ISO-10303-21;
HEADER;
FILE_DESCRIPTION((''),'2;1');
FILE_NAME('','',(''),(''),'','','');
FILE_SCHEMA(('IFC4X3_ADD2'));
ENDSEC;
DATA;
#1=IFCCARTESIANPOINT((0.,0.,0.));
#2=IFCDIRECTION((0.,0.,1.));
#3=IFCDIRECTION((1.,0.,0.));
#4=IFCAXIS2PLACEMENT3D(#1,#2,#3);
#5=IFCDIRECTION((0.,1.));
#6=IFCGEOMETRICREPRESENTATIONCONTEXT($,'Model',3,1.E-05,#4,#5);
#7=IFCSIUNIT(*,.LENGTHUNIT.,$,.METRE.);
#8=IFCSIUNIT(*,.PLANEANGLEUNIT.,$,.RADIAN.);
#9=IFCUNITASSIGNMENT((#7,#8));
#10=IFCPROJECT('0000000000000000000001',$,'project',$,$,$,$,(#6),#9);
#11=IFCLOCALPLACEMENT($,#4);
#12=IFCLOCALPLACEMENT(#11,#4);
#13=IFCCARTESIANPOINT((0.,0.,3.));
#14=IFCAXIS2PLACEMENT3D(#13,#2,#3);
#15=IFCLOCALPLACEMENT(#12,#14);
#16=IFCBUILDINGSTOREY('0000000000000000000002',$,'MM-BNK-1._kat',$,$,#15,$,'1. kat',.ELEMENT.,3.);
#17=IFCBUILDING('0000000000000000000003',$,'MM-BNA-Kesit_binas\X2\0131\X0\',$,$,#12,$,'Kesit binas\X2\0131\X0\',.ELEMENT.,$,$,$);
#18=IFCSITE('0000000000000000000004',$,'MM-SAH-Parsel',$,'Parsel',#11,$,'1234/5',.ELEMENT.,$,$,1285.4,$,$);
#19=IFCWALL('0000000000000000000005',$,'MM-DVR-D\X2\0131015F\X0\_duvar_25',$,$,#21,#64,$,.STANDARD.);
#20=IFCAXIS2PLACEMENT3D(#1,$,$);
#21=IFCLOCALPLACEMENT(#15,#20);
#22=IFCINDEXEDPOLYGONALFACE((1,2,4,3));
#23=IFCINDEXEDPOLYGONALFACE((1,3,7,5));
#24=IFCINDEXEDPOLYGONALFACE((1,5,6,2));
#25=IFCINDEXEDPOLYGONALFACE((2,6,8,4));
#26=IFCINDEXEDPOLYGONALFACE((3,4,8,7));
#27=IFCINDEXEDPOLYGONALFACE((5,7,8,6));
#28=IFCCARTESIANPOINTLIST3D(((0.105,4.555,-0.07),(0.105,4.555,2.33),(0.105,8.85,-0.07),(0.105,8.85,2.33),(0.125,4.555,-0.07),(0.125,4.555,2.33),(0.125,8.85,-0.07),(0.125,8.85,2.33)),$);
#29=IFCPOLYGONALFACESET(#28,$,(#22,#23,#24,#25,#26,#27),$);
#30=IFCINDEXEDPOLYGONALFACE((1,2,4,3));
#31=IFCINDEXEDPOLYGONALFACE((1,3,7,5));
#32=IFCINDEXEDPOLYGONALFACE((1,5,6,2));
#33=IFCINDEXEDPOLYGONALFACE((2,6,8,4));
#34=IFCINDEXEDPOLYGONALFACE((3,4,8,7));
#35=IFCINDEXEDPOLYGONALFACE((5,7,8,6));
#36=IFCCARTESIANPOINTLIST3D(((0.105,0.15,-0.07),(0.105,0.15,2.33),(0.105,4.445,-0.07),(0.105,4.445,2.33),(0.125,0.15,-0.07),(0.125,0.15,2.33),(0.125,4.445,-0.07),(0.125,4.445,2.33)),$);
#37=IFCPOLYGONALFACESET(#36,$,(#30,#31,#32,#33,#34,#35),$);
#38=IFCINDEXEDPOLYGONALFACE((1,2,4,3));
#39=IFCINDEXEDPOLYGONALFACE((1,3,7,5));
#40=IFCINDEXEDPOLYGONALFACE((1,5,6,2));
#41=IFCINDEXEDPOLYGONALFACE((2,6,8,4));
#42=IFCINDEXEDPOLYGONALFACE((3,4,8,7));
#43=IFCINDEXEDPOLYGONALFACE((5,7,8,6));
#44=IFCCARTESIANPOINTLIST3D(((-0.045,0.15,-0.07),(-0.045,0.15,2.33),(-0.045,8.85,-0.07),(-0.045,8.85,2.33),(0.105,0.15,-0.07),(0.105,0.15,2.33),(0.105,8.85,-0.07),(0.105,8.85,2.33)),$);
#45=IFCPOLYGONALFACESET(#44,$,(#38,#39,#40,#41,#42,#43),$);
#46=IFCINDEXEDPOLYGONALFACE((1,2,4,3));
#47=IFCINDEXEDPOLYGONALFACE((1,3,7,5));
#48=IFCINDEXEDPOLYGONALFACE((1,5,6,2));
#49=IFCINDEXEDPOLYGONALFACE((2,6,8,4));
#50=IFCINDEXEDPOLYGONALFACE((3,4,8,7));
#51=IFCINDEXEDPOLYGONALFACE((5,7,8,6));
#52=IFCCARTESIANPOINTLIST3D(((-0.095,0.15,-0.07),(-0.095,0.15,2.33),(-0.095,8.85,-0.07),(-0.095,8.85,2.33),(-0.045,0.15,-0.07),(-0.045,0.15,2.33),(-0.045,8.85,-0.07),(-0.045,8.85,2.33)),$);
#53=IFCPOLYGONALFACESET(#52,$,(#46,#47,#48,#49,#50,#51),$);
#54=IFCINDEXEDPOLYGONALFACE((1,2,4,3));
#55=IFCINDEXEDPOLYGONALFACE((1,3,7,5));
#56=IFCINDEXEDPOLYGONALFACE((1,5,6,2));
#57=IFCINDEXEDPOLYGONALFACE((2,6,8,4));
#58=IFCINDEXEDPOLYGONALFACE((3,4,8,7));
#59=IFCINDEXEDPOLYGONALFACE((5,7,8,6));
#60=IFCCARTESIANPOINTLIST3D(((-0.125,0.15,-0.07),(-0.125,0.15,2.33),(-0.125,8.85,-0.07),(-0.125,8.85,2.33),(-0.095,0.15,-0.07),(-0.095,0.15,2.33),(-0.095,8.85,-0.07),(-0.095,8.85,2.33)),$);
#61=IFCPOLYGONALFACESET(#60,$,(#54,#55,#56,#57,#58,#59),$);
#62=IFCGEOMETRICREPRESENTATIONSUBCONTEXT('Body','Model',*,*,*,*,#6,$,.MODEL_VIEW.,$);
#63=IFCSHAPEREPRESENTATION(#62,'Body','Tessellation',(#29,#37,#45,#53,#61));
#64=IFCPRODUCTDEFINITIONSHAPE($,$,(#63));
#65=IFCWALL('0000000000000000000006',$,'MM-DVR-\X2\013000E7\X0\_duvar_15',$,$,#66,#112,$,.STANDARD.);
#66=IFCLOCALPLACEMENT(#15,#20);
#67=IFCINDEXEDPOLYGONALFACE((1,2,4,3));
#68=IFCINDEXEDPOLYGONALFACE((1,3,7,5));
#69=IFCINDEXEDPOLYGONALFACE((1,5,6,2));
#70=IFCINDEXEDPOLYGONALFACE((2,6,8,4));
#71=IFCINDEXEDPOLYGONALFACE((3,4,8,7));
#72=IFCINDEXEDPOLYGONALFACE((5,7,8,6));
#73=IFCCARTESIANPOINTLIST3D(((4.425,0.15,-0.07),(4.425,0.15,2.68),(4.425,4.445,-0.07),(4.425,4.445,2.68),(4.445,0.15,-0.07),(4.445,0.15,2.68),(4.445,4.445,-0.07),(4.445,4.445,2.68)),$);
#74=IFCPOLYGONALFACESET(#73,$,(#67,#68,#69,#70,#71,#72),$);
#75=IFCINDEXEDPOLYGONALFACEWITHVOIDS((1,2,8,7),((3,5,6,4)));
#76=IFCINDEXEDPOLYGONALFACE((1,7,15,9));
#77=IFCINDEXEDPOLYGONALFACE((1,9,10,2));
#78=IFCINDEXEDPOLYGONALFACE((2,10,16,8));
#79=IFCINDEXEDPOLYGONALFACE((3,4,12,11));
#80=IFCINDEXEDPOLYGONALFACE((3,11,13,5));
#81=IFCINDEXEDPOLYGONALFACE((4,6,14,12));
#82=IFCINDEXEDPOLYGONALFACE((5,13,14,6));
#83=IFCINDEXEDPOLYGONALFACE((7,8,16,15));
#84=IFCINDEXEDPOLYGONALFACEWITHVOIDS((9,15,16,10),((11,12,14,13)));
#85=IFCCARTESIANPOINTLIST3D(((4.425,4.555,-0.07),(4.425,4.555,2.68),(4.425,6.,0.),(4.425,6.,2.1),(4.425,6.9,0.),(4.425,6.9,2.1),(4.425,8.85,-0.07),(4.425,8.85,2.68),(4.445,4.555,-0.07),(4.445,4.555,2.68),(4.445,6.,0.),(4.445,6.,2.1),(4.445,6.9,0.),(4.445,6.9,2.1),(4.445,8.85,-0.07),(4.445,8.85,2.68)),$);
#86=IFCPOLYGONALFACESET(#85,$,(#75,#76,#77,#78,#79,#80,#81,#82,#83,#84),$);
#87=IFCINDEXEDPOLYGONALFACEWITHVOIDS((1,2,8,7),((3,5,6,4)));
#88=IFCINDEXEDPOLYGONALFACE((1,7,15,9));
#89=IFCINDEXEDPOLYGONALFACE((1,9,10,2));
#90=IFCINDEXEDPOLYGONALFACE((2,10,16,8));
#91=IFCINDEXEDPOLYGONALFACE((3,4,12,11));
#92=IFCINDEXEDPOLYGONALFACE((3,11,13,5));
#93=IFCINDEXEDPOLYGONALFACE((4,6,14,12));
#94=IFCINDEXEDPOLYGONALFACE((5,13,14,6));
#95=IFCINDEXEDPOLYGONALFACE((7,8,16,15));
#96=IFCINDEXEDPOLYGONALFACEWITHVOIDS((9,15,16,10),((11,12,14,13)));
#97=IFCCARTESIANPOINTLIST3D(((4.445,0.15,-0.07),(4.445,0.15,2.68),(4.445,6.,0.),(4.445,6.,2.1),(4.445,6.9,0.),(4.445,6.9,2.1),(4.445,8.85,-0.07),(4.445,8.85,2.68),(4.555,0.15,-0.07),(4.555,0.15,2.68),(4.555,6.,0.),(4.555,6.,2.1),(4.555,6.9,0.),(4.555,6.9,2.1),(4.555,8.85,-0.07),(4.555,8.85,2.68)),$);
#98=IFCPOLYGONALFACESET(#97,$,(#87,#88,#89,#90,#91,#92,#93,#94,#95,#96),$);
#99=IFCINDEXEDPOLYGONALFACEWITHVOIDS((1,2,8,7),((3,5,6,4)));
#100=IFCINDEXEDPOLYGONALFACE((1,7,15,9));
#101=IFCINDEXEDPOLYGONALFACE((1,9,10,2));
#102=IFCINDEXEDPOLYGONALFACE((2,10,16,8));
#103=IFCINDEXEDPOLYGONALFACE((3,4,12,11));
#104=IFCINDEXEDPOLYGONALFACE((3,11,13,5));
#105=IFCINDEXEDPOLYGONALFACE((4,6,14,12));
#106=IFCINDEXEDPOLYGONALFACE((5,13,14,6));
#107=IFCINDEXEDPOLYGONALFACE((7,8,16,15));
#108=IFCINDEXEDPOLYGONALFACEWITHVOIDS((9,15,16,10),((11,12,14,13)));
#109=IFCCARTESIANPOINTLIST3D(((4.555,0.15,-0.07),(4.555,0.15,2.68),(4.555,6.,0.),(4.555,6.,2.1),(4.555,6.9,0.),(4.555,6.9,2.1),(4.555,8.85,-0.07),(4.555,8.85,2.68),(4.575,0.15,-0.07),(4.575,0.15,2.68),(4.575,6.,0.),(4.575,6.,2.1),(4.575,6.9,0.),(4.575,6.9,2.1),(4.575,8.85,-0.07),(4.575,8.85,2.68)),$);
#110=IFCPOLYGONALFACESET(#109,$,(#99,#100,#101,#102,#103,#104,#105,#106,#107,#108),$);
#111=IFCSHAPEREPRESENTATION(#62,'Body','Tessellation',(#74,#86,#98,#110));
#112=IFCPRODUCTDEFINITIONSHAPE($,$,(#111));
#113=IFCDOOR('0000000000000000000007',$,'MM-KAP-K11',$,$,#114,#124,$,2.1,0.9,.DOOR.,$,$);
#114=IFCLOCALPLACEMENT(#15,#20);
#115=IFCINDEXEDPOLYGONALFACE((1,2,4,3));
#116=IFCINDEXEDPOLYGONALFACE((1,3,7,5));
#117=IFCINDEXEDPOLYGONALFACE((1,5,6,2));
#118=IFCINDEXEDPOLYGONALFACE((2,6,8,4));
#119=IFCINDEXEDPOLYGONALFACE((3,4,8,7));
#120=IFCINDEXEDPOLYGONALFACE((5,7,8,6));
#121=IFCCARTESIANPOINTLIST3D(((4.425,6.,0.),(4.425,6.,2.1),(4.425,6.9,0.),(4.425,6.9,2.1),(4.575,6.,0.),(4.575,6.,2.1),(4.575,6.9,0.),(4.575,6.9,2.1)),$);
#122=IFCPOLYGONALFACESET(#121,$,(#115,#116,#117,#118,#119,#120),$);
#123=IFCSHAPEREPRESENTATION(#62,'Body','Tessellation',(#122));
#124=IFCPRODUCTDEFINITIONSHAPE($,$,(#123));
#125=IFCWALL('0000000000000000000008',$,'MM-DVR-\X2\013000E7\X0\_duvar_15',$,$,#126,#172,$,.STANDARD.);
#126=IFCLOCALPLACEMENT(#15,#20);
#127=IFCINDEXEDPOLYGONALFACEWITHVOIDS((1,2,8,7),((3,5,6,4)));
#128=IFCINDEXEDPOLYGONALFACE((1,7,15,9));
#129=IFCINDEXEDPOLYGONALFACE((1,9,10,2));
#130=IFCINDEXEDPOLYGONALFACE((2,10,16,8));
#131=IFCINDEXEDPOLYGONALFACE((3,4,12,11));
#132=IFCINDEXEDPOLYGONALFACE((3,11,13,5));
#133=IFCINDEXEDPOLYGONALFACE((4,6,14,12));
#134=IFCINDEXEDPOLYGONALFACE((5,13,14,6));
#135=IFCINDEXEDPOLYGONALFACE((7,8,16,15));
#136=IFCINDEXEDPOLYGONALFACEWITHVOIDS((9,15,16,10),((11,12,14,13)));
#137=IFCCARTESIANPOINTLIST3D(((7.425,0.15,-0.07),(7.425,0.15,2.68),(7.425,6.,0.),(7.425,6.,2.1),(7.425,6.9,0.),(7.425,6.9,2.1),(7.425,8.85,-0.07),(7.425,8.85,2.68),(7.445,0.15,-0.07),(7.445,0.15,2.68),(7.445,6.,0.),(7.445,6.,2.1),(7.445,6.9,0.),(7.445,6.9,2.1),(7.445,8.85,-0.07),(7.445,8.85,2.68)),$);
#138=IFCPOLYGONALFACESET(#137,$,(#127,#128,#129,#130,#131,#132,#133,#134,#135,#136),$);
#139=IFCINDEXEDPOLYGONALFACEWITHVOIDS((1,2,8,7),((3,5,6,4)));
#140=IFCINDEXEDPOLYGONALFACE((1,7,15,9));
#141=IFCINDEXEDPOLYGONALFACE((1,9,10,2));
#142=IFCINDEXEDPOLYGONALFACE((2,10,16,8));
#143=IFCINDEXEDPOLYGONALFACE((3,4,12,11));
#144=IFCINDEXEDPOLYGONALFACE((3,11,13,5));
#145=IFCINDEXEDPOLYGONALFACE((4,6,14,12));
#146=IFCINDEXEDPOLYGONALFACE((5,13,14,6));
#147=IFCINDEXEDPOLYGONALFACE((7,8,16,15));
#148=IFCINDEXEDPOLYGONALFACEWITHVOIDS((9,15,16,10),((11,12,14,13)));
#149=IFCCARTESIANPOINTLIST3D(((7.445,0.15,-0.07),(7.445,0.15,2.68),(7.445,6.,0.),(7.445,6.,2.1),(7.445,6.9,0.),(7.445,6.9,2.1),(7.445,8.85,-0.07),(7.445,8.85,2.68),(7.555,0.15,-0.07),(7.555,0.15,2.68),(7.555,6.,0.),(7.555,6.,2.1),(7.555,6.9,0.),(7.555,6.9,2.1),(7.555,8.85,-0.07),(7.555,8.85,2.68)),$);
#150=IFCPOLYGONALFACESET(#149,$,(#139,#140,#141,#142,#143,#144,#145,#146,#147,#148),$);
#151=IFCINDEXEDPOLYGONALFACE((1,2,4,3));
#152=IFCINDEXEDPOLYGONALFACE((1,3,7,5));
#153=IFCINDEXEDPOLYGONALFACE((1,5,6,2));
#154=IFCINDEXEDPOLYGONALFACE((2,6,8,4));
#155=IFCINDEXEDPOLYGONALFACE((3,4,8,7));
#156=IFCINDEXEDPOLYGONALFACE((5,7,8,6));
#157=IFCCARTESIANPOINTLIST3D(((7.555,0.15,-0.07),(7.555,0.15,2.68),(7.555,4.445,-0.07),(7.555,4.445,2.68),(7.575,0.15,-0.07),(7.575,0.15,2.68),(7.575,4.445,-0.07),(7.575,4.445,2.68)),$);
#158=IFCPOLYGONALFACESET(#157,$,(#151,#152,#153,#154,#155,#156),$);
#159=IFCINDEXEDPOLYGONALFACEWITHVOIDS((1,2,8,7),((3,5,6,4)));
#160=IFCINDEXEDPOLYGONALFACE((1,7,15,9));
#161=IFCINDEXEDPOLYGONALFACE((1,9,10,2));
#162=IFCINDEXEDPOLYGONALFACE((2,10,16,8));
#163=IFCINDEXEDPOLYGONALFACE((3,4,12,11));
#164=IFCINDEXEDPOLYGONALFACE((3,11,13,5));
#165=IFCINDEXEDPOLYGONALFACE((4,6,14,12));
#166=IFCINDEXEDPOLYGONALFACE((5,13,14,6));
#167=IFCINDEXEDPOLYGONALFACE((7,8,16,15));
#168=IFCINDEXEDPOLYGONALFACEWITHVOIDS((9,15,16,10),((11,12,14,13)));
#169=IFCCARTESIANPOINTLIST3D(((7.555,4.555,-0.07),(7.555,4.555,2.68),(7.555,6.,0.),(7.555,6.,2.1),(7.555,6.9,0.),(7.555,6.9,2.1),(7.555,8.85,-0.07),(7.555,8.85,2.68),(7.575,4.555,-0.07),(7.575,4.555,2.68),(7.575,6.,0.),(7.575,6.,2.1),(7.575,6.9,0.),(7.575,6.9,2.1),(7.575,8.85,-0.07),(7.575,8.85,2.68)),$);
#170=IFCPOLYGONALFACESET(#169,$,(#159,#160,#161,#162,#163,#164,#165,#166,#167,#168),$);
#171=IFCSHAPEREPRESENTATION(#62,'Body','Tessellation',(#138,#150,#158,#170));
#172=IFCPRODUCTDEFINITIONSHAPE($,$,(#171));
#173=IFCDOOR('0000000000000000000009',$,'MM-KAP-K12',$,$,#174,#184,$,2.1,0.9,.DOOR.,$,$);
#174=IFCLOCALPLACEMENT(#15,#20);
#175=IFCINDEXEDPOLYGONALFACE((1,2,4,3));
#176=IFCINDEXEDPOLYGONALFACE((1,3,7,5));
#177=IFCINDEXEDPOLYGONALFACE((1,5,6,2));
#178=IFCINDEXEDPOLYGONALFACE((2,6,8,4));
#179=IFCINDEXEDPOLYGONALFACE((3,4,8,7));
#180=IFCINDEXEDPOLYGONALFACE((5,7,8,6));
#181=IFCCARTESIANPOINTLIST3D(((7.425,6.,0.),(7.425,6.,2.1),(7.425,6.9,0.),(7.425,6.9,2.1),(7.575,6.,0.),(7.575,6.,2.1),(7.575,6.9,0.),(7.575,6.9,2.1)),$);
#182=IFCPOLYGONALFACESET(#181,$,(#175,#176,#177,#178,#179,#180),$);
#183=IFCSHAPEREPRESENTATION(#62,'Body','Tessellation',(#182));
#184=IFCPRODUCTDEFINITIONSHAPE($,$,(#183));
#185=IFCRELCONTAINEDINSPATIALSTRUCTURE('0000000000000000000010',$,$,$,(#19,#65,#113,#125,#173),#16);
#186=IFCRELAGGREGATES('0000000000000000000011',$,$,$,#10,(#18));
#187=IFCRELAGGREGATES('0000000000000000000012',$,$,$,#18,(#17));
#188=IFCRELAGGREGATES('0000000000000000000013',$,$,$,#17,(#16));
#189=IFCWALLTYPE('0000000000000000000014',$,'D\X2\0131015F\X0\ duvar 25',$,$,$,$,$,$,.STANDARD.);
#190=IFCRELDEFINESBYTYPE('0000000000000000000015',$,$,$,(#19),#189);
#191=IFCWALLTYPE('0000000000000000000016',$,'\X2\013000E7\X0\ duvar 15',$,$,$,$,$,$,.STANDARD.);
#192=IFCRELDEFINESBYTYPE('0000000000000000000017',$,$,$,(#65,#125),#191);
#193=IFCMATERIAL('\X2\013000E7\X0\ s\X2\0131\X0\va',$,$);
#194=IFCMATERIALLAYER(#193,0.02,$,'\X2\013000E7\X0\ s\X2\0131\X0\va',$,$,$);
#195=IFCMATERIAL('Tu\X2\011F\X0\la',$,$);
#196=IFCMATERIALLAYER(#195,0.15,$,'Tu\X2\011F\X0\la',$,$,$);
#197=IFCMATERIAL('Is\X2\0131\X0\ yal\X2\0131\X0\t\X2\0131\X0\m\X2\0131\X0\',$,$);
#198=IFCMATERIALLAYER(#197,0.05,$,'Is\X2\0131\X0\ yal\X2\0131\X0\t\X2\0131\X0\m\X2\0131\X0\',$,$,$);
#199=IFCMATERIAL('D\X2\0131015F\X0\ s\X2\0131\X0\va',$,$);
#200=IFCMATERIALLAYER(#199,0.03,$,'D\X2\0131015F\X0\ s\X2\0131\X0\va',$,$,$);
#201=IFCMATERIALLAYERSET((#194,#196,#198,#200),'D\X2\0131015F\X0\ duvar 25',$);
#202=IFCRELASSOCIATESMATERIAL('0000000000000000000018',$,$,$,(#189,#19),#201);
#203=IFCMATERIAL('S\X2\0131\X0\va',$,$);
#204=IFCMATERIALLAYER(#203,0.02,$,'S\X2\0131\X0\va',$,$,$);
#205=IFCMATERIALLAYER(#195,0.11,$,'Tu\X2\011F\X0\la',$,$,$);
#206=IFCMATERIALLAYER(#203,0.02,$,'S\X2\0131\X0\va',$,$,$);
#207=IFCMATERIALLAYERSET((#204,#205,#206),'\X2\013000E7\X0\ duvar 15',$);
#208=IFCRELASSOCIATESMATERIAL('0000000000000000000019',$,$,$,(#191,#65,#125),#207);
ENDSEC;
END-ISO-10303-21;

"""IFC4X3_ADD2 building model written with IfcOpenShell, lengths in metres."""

from ifc_helpers import new_model, si_unit, direction, frame, origin, origin_with_axes, place, context, subcontext, project, spatial, polyline, outline, extrude, material, layer, layer_set, type_object, element, fill, save


model = new_model("IFC4X3_ADD2")

# Units and contexts
model_context = context("Model", 3, precision=1e-05, world=origin_with_axes(), true_north=direction((0.0, 1.0)))
body_context = subcontext(model_context, "Body", "Model", "MODEL_VIEW")
ifc_project = project(units=[si_unit("LENGTHUNIT", "METRE"), si_unit("PLANEANGLEUNIT", "RADIAN")], contexts=[model_context])

# Site, building, storey
site_placement = place(None, origin_with_axes())
site = spatial("IfcSite", under=ifc_project, at=site_placement, Name="MM-SAH-Parsel", ObjectType="Parsel", LongName="1234/5", CompositionType="ELEMENT", RefElevation=1285.4)
building_placement = place(site_placement, origin_with_axes())
building = spatial("IfcBuilding", under=site, at=building_placement, Name="MM-BNA-Kesit_binası", LongName="Kesit binası", CompositionType="ELEMENT")
storey_placement = place(building_placement, frame((0.0, 0.0, 3.0), z_axis=(0.0, 0.0, 1.0), x_axis=(1.0, 0.0, 0.0)))
storey = spatial("IfcBuildingStorey", under=building, at=storey_placement, Name="MM-BNK-1._kat", LongName="1. kat", CompositionType="ELEMENT", Elevation=3.0)

# Shared definitions
ifc_material_1 = material(Name="İç sıva")
ifc_layer_1 = layer(ifc_material_1, 0.02, Name="İç sıva")
ifc_material_2 = material(Name="Tuğla")
ifc_layer_2 = layer(ifc_material_2, 0.15, Name="Tuğla")
ifc_material_3 = material(Name="Isı yalıtımı")
ifc_layer_3 = layer(ifc_material_3, 0.05, Name="Isı yalıtımı")
ifc_material_4 = material(Name="Dış sıva")
ifc_layer_4 = layer(ifc_material_4, 0.03, Name="Dış sıva")
ifc_layer_set_1 = layer_set([ifc_layer_1, ifc_layer_2, ifc_layer_3, ifc_layer_4], Name="Dış duvar 25")
wall_type_1 = type_object("IfcWallType", Name="Dış duvar 25", PredefinedType="STANDARD", material=ifc_layer_set_1)

# Wall
wall_1_placement = place(storey_placement, origin_with_axes())
element("IfcWall", 1, at=wall_1_placement, inside=storey, type_object=wall_type_1, material=ifc_layer_set_1, Name="MM-DVR-Dış_duvar_25", PredefinedType="STANDARD", context=body_context, shape_type="SweptSolid", body=[
    extrude(outline(polyline([(0.105, 8.85), (0.105, 4.555), (0.125, 4.555), (0.125, 8.85), (0.105, 8.85)])), frame((0.0, 0.0, -0.07)), (0.0, 0.0, 1.0), 2.4),
    extrude(outline(polyline([(0.105, 4.445), (0.105, 0.15), (0.125, 0.15), (0.125, 4.445), (0.105, 4.445)])), frame((0.0, 0.0, -0.07)), (0.0, 0.0, 1.0), 2.4),
    extrude(outline(polyline([(-0.045, 8.85), (-0.045, 0.15), (0.105, 0.15), (0.105, 8.85), (-0.045, 8.85)])), frame((0.0, 0.0, -0.07)), (0.0, 0.0, 1.0), 2.4),
    extrude(outline(polyline([(-0.095, 8.85), (-0.095, 0.15), (-0.045, 0.15), (-0.045, 8.85), (-0.095, 8.85)])), frame((0.0, 0.0, -0.07)), (0.0, 0.0, 1.0), 2.4),
    extrude(outline(polyline([(-0.125, 8.85), (-0.125, 0.15), (-0.095, 0.15), (-0.095, 8.85), (-0.125, 8.85)])), frame((0.0, 0.0, -0.07)), (0.0, 0.0, 1.0), 2.4),
])

# Walls, openings, doors
ifc_material_5 = material(Name="Sıva")
ifc_layer_5 = layer(ifc_material_5, 0.02, Name="Sıva")
ifc_layer_6 = layer(ifc_material_2, 0.11, Name="Tuğla")
ifc_layer_7 = layer(ifc_material_5, 0.02, Name="Sıva")
ifc_layer_set_2 = layer_set([ifc_layer_5, ifc_layer_6, ifc_layer_7], Name="İç duvar 15")
wall_type_2 = type_object("IfcWallType", Name="İç duvar 15", PredefinedType="STANDARD", material=ifc_layer_set_2)
wall_2_placement = place(storey_placement, origin_with_axes())
wall_2 = element("IfcWall", 2, at=wall_2_placement, inside=storey, type_object=wall_type_2, material=ifc_layer_set_2, Name="MM-DVR-İç_duvar_15", PredefinedType="STANDARD", context=body_context, shape_type="SweptSolid", body=[
    extrude(outline(polyline([(4.445, 0.15), (4.445, 4.445), (4.425, 4.445), (4.425, 0.15), (4.445, 0.15)])), frame((0.0, 0.0, -0.07)), (0.0, 0.0, 1.0), 2.75),
    extrude(outline(polyline([(4.445, 4.555), (4.445, 8.85), (4.425, 8.85), (4.425, 4.555), (4.445, 4.555)])), frame((0.0, 0.0, -0.07)), (0.0, 0.0, 1.0), 2.75),
    extrude(outline(polyline([(4.555, 0.15), (4.555, 8.85), (4.445, 8.85), (4.445, 0.15), (4.555, 0.15)])), frame((0.0, 0.0, -0.07)), (0.0, 0.0, 1.0), 2.75),
    extrude(outline(polyline([(4.575, 0.15), (4.575, 8.85), (4.555, 8.85), (4.555, 0.15), (4.575, 0.15)])), frame((0.0, 0.0, -0.07)), (0.0, 0.0, 1.0), 2.75),
])
opening_1_placement = place(storey_placement, origin_with_axes())
opening_1 = element("IfcOpeningElement", 3, at=opening_1_placement, cuts=wall_2, PredefinedType="OPENING", context=body_context, shape_type="SweptSolid", body=[
    extrude(outline(polyline([(4.425, 6.0), (4.425, 6.9), (4.575, 6.9), (4.575, 6.0), (4.425, 6.0)])), origin(), (0.0, 0.0, 1.0), 2.1),
])
door_1_placement = place(storey_placement, origin_with_axes())
door_1 = element("IfcDoor", 4, at=door_1_placement, inside=storey, Name="MM-KAP-K11", OverallHeight=2.1, OverallWidth=0.9, PredefinedType="DOOR", context=body_context, shape_type="SweptSolid", body=[
    extrude(outline(polyline([(4.425, 6.0), (4.425, 6.9), (4.575, 6.9), (4.575, 6.0), (4.425, 6.0)])), origin(), (0.0, 0.0, 1.0), 2.1),
])
fill(opening_1, door_1)
wall_3_placement = place(storey_placement, origin_with_axes())
wall_3 = element("IfcWall", 5, at=wall_3_placement, inside=storey, type_object=wall_type_2, material=ifc_layer_set_2, Name="MM-DVR-İç_duvar_15", PredefinedType="STANDARD", context=body_context, shape_type="SweptSolid", body=[
    extrude(outline(polyline([(7.445, 0.15), (7.445, 8.85), (7.425, 8.85), (7.425, 0.15), (7.445, 0.15)])), frame((0.0, 0.0, -0.07)), (0.0, 0.0, 1.0), 2.75),
    extrude(outline(polyline([(7.555, 0.15), (7.555, 8.85), (7.445, 8.85), (7.445, 0.15), (7.555, 0.15)])), frame((0.0, 0.0, -0.07)), (0.0, 0.0, 1.0), 2.75),
    extrude(outline(polyline([(7.575, 0.15), (7.575, 4.445), (7.555, 4.445), (7.555, 0.15), (7.575, 0.15)])), frame((0.0, 0.0, -0.07)), (0.0, 0.0, 1.0), 2.75),
    extrude(outline(polyline([(7.575, 4.555), (7.575, 8.85), (7.555, 8.85), (7.555, 4.555), (7.575, 4.555)])), frame((0.0, 0.0, -0.07)), (0.0, 0.0, 1.0), 2.75),
])
opening_2_placement = place(storey_placement, origin_with_axes())
opening_2 = element("IfcOpeningElement", 6, at=opening_2_placement, cuts=wall_3, PredefinedType="OPENING", context=body_context, shape_type="SweptSolid", body=[
    extrude(outline(polyline([(7.425, 6.0), (7.425, 6.9), (7.575, 6.9), (7.575, 6.0), (7.425, 6.0)])), origin(), (0.0, 0.0, 1.0), 2.1),
])
door_2_placement = place(storey_placement, origin_with_axes())
door_2 = element("IfcDoor", 7, at=door_2_placement, inside=storey, Name="MM-KAP-K12", OverallHeight=2.1, OverallWidth=0.9, PredefinedType="DOOR", context=body_context, shape_type="SweptSolid", body=[
    extrude(outline(polyline([(7.425, 6.0), (7.425, 6.9), (7.575, 6.9), (7.575, 6.0), (7.425, 6.0)])), origin(), (0.0, 0.0, 1.0), 2.1),
])
fill(opening_2, door_2)

save(model, "model.ifc")
